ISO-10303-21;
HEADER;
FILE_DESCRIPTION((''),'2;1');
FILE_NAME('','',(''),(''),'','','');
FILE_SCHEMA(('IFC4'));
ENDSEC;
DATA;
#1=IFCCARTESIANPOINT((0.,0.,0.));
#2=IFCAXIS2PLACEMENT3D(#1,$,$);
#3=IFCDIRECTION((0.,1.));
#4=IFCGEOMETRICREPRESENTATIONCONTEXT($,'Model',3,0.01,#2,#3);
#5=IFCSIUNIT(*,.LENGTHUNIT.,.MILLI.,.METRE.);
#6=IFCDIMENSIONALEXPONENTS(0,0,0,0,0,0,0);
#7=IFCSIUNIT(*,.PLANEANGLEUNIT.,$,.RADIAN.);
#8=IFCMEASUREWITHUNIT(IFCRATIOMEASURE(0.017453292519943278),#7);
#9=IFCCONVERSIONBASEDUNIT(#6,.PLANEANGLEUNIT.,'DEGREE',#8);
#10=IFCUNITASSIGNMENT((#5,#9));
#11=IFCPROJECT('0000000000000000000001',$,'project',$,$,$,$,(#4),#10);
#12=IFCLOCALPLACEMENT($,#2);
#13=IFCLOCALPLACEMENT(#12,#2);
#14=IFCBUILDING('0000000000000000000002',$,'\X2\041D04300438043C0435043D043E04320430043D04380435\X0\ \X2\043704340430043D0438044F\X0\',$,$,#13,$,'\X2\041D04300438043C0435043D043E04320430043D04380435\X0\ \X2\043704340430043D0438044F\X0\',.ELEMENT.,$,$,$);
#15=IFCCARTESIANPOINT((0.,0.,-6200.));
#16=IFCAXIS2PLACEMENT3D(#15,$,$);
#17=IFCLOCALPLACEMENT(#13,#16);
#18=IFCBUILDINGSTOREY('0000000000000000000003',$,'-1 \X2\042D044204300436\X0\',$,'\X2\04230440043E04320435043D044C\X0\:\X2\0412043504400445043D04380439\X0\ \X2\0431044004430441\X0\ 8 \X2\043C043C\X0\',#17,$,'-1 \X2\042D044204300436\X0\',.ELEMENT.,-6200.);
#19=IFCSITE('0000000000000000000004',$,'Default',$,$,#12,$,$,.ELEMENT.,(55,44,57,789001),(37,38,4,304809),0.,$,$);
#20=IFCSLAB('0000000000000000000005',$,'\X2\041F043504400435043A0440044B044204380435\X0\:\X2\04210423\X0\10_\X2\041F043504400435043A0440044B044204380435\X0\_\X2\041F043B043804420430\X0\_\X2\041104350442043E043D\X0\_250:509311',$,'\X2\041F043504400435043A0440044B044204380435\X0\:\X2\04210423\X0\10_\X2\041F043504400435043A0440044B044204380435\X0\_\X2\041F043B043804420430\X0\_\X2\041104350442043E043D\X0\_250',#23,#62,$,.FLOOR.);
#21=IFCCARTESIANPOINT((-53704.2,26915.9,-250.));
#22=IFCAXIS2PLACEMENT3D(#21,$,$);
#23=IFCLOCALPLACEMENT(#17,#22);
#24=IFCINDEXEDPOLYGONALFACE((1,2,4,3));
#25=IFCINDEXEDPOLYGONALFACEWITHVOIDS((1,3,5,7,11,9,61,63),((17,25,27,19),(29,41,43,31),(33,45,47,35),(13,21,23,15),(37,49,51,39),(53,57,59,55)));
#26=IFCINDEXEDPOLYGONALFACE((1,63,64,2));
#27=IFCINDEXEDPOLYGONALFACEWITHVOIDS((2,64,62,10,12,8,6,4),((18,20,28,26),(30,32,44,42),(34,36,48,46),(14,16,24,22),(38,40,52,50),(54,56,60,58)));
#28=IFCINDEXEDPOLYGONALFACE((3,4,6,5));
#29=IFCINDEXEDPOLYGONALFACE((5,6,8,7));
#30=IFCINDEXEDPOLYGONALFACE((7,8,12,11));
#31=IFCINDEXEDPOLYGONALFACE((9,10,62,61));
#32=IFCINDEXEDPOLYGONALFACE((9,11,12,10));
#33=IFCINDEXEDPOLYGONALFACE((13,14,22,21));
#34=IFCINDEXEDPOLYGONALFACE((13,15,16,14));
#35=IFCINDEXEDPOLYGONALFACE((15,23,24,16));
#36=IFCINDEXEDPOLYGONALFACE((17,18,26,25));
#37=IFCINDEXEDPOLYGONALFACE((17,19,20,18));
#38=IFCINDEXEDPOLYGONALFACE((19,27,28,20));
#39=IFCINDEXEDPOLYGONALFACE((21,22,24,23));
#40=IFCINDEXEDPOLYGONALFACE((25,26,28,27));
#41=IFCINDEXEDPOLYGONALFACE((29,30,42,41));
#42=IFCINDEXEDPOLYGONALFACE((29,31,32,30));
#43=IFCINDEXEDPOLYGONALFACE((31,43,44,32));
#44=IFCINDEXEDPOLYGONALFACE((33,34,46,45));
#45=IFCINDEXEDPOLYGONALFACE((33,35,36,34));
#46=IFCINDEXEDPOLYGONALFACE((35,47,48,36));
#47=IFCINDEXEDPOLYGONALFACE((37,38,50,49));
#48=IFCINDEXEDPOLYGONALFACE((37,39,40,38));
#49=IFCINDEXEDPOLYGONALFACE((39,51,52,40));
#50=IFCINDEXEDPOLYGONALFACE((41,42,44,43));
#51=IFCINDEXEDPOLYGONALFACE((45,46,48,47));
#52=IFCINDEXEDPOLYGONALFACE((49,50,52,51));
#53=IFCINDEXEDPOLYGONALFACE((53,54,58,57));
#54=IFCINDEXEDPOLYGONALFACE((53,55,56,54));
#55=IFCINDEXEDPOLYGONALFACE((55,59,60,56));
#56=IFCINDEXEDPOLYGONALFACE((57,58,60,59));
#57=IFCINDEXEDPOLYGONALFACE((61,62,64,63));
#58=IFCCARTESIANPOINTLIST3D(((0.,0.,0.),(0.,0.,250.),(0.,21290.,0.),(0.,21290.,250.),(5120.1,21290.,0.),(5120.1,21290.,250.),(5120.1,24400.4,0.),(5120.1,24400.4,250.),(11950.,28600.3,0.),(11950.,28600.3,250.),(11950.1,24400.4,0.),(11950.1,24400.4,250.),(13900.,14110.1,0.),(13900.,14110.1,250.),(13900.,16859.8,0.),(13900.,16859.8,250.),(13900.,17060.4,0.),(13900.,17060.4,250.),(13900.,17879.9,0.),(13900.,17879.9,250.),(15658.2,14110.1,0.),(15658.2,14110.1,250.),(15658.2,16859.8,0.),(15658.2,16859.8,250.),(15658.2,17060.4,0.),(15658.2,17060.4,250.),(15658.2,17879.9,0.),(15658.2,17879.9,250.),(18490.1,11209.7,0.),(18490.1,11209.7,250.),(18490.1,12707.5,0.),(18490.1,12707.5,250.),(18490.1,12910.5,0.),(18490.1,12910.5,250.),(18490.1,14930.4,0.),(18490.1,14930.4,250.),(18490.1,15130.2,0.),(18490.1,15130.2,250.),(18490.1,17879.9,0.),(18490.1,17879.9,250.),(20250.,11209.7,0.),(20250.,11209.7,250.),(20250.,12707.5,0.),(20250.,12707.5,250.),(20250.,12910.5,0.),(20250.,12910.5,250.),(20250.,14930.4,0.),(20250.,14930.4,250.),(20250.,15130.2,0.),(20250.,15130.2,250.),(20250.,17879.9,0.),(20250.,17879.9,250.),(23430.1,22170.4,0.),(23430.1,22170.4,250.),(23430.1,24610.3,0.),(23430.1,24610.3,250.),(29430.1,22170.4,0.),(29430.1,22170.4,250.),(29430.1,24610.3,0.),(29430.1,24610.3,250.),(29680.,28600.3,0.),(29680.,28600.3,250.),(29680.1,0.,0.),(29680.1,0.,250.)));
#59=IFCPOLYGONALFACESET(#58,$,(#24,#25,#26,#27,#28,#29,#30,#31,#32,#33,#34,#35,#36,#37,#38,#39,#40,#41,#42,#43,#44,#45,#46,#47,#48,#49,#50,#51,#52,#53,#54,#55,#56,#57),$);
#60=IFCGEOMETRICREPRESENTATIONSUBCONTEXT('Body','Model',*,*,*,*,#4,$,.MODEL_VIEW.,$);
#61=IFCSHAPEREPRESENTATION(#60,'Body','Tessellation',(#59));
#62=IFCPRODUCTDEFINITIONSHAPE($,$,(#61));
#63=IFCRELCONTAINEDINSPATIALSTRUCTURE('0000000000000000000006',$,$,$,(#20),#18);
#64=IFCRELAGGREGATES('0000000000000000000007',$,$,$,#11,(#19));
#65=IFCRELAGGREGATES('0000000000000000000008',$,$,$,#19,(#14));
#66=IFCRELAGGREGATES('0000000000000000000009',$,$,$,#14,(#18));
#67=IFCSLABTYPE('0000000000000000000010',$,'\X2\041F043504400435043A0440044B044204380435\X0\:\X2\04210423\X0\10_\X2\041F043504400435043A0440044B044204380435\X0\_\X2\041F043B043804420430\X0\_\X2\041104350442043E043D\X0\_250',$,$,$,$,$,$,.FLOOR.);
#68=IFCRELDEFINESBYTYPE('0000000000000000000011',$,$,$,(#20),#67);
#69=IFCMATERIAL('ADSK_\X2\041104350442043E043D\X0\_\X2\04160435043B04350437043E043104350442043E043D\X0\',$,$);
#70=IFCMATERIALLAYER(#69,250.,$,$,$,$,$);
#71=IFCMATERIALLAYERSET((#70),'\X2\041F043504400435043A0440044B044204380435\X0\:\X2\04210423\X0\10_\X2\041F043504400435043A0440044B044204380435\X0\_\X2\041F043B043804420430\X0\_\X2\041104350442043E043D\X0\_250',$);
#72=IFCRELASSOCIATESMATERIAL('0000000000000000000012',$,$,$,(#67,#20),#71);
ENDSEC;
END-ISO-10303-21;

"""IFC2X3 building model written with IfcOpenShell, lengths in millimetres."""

from ifc_helpers import new_model, entity, si_unit, converted_unit, direction, frame, origin, origin_2d_with_axis, place, context, subcontext, project, spatial, polyline, rectangle, outline, extrude, material, layer, layer_set, layer_usage, type_object, element, save


model = new_model("IFC2X3")

# Units and contexts
model_context = context("Model", 3, precision=0.01, world=origin(), true_north=direction((0.0, 1.0)))
body_context = subcontext(model_context, "Body", "Model", "MODEL_VIEW")
ifc_project = project(units=[si_unit("LENGTHUNIT", "METRE", prefix="MILLI"), converted_unit("PLANEANGLEUNIT", "DEGREE", entity("IfcRatioMeasure", 0.017453292519943278), si_unit("PLANEANGLEUNIT", "RADIAN"), dimensions=[0, 0, 0, 0, 0, 0, 0])], contexts=[model_context])

# Site, building, storey
site_placement = place(None, origin())
site = spatial("IfcSite", under=ifc_project, at=site_placement, Name="Default", CompositionType="ELEMENT", RefLatitude=(55, 44, 57, 789001), RefLongitude=(37, 38, 4, 304809), RefElevation=0.0)
building_placement = place(site_placement, origin())
building = spatial("IfcBuilding", under=site, at=building_placement, Name="Наименование здания", LongName="Наименование здания", CompositionType="ELEMENT")
storey_placement = place(building_placement, frame((0.0, 0.0, -6200.0)))
storey = spatial("IfcBuildingStorey", under=building, at=storey_placement, Name="-1 Этаж", ObjectType="Уровень:Верхний брус 8 мм", LongName="-1 Этаж", CompositionType="ELEMENT", Elevation=-6200.0)

# Slab, openings
ifc_material_1 = material(Name="ADSK_Бетон_Железобетон")
ifc_layer_1 = layer(ifc_material_1, 250.0)
ifc_layer_set_1 = layer_set([ifc_layer_1], Name="Перекрытие:СУ10_Перекрытие_Плита_Бетон_250")
ifc_layer_usage_1 = layer_usage(ifc_layer_set_1, "AXIS3", "POSITIVE", 0.0)
slab_type_1 = type_object("IfcSlabType", Name="Перекрытие:СУ10_Перекрытие_Плита_Бетон_250", PredefinedType="FLOOR", material=ifc_layer_set_1)
slab_1_placement = place(storey_placement, frame((-53704.2, 26915.9, -250.0)))
slab_1 = element("IfcSlab", 1, at=slab_1_placement, inside=storey, type_object=slab_type_1, material=ifc_layer_usage_1, Name="Перекрытие:СУ10_Перекрытие_Плита_Бетон_250:509311", ObjectType="Перекрытие:СУ10_Перекрытие_Плита_Бетон_250", PredefinedType="FLOOR", context=body_context, shape_type="SweptSolid", body=[
    extrude(outline(polyline([(9720.0, 6989.9), (9720.0, 10100.2), (2890.0, 10100.2), (2890.0, 14300.1), (-14840.0, 14300.1), (-14840.1, -14300.1), (14840.1, -14300.1), (14840.1, 6989.9), (9720.0, 6989.9)])), frame((14840.1, 14300.1, 250.0), z_axis=(0.0, 0.0, -1.0), x_axis=(-1.0, 0.0, 0.0)), (0.0, 0.0, 1.0), 250.0),
])
opening_1_placement = place(slab_1_placement, frame((19370.1, 16505.1, 250.0)))
element("IfcOpeningElement", 2, at=opening_1_placement, cuts=slab_1, ObjectType="Opening", context=body_context, shape_type="SweptSolid", body=[
    extrude(rectangle(XDim=2749.7, YDim=1760.0, at=origin_2d_with_axis()), frame((0.0, 0.0, 0.0), z_axis=(0.0, 0.0, -1.0), x_axis=(0.0, -1.0, 0.0)), (0.0, 0.0, 1.0), 250.0),
])
opening_2_placement = place(slab_1_placement, frame((19370.1, 13920.4, 250.0)))
element("IfcOpeningElement", 3, at=opening_2_placement, cuts=slab_1, ObjectType="Opening", context=body_context, shape_type="SweptSolid", body=[
    extrude(rectangle(XDim=2020.0, YDim=1760.0, at=origin_2d_with_axis()), frame((0.0, 0.0, 0.0), z_axis=(0.0, 0.0, -1.0), x_axis=(0.0, -1.0, 0.0)), (0.0, 0.0, 1.0), 250.0),
])
opening_3_placement = place(slab_1_placement, frame((19370.1, 11958.6, 250.0)))
element("IfcOpeningElement", 4, at=opening_3_placement, cuts=slab_1, ObjectType="Opening", context=body_context, shape_type="SweptSolid", body=[
    extrude(rectangle(XDim=1497.9, YDim=1760.0, at=origin_2d_with_axis()), frame((0.0, 0.0, 0.0), z_axis=(0.0, 0.0, -1.0), x_axis=(0.0, -1.0, 0.0)), (0.0, 0.0, 1.0), 250.0),
])
opening_4_placement = place(slab_1_placement, frame((14779.1, 17470.2, 250.0)))
element("IfcOpeningElement", 5, at=opening_4_placement, cuts=slab_1, ObjectType="Opening", context=body_context, shape_type="SweptSolid", body=[
    extrude(rectangle(XDim=819.5, YDim=1758.1, at=origin_2d_with_axis()), frame((0.0, 0.0, 0.0), z_axis=(0.0, 0.0, -1.0), x_axis=(0.0, -1.0, 0.0)), (0.0, 0.0, 1.0), 250.0),
])
opening_5_placement = place(slab_1_placement, frame((14779.1, 15484.9, 250.0)))
element("IfcOpeningElement", 6, at=opening_5_placement, cuts=slab_1, ObjectType="Opening", context=body_context, shape_type="SweptSolid", body=[
    extrude(rectangle(XDim=2749.7, YDim=1758.1, at=origin_2d_with_axis()), frame((0.0, 0.0, 0.0), z_axis=(0.0, 0.0, -1.0), x_axis=(0.0, -1.0, 0.0)), (0.0, 0.0, 1.0), 250.0),
])
opening_6_placement = place(slab_1_placement, frame((26430.1, 23390.4, 250.0)))
element("IfcOpeningElement", 7, at=opening_6_placement, cuts=slab_1, ObjectType="Opening", context=body_context, shape_type="SweptSolid", body=[
    extrude(rectangle(XDim=2439.9, YDim=6000.0, at=origin_2d_with_axis()), frame((0.0, 0.0, 0.0), z_axis=(0.0, 0.0, -1.0), x_axis=(0.0, -1.0, 0.0)), (0.0, 0.0, 1.0), 250.0),
])

save(model, "model.ifc")
